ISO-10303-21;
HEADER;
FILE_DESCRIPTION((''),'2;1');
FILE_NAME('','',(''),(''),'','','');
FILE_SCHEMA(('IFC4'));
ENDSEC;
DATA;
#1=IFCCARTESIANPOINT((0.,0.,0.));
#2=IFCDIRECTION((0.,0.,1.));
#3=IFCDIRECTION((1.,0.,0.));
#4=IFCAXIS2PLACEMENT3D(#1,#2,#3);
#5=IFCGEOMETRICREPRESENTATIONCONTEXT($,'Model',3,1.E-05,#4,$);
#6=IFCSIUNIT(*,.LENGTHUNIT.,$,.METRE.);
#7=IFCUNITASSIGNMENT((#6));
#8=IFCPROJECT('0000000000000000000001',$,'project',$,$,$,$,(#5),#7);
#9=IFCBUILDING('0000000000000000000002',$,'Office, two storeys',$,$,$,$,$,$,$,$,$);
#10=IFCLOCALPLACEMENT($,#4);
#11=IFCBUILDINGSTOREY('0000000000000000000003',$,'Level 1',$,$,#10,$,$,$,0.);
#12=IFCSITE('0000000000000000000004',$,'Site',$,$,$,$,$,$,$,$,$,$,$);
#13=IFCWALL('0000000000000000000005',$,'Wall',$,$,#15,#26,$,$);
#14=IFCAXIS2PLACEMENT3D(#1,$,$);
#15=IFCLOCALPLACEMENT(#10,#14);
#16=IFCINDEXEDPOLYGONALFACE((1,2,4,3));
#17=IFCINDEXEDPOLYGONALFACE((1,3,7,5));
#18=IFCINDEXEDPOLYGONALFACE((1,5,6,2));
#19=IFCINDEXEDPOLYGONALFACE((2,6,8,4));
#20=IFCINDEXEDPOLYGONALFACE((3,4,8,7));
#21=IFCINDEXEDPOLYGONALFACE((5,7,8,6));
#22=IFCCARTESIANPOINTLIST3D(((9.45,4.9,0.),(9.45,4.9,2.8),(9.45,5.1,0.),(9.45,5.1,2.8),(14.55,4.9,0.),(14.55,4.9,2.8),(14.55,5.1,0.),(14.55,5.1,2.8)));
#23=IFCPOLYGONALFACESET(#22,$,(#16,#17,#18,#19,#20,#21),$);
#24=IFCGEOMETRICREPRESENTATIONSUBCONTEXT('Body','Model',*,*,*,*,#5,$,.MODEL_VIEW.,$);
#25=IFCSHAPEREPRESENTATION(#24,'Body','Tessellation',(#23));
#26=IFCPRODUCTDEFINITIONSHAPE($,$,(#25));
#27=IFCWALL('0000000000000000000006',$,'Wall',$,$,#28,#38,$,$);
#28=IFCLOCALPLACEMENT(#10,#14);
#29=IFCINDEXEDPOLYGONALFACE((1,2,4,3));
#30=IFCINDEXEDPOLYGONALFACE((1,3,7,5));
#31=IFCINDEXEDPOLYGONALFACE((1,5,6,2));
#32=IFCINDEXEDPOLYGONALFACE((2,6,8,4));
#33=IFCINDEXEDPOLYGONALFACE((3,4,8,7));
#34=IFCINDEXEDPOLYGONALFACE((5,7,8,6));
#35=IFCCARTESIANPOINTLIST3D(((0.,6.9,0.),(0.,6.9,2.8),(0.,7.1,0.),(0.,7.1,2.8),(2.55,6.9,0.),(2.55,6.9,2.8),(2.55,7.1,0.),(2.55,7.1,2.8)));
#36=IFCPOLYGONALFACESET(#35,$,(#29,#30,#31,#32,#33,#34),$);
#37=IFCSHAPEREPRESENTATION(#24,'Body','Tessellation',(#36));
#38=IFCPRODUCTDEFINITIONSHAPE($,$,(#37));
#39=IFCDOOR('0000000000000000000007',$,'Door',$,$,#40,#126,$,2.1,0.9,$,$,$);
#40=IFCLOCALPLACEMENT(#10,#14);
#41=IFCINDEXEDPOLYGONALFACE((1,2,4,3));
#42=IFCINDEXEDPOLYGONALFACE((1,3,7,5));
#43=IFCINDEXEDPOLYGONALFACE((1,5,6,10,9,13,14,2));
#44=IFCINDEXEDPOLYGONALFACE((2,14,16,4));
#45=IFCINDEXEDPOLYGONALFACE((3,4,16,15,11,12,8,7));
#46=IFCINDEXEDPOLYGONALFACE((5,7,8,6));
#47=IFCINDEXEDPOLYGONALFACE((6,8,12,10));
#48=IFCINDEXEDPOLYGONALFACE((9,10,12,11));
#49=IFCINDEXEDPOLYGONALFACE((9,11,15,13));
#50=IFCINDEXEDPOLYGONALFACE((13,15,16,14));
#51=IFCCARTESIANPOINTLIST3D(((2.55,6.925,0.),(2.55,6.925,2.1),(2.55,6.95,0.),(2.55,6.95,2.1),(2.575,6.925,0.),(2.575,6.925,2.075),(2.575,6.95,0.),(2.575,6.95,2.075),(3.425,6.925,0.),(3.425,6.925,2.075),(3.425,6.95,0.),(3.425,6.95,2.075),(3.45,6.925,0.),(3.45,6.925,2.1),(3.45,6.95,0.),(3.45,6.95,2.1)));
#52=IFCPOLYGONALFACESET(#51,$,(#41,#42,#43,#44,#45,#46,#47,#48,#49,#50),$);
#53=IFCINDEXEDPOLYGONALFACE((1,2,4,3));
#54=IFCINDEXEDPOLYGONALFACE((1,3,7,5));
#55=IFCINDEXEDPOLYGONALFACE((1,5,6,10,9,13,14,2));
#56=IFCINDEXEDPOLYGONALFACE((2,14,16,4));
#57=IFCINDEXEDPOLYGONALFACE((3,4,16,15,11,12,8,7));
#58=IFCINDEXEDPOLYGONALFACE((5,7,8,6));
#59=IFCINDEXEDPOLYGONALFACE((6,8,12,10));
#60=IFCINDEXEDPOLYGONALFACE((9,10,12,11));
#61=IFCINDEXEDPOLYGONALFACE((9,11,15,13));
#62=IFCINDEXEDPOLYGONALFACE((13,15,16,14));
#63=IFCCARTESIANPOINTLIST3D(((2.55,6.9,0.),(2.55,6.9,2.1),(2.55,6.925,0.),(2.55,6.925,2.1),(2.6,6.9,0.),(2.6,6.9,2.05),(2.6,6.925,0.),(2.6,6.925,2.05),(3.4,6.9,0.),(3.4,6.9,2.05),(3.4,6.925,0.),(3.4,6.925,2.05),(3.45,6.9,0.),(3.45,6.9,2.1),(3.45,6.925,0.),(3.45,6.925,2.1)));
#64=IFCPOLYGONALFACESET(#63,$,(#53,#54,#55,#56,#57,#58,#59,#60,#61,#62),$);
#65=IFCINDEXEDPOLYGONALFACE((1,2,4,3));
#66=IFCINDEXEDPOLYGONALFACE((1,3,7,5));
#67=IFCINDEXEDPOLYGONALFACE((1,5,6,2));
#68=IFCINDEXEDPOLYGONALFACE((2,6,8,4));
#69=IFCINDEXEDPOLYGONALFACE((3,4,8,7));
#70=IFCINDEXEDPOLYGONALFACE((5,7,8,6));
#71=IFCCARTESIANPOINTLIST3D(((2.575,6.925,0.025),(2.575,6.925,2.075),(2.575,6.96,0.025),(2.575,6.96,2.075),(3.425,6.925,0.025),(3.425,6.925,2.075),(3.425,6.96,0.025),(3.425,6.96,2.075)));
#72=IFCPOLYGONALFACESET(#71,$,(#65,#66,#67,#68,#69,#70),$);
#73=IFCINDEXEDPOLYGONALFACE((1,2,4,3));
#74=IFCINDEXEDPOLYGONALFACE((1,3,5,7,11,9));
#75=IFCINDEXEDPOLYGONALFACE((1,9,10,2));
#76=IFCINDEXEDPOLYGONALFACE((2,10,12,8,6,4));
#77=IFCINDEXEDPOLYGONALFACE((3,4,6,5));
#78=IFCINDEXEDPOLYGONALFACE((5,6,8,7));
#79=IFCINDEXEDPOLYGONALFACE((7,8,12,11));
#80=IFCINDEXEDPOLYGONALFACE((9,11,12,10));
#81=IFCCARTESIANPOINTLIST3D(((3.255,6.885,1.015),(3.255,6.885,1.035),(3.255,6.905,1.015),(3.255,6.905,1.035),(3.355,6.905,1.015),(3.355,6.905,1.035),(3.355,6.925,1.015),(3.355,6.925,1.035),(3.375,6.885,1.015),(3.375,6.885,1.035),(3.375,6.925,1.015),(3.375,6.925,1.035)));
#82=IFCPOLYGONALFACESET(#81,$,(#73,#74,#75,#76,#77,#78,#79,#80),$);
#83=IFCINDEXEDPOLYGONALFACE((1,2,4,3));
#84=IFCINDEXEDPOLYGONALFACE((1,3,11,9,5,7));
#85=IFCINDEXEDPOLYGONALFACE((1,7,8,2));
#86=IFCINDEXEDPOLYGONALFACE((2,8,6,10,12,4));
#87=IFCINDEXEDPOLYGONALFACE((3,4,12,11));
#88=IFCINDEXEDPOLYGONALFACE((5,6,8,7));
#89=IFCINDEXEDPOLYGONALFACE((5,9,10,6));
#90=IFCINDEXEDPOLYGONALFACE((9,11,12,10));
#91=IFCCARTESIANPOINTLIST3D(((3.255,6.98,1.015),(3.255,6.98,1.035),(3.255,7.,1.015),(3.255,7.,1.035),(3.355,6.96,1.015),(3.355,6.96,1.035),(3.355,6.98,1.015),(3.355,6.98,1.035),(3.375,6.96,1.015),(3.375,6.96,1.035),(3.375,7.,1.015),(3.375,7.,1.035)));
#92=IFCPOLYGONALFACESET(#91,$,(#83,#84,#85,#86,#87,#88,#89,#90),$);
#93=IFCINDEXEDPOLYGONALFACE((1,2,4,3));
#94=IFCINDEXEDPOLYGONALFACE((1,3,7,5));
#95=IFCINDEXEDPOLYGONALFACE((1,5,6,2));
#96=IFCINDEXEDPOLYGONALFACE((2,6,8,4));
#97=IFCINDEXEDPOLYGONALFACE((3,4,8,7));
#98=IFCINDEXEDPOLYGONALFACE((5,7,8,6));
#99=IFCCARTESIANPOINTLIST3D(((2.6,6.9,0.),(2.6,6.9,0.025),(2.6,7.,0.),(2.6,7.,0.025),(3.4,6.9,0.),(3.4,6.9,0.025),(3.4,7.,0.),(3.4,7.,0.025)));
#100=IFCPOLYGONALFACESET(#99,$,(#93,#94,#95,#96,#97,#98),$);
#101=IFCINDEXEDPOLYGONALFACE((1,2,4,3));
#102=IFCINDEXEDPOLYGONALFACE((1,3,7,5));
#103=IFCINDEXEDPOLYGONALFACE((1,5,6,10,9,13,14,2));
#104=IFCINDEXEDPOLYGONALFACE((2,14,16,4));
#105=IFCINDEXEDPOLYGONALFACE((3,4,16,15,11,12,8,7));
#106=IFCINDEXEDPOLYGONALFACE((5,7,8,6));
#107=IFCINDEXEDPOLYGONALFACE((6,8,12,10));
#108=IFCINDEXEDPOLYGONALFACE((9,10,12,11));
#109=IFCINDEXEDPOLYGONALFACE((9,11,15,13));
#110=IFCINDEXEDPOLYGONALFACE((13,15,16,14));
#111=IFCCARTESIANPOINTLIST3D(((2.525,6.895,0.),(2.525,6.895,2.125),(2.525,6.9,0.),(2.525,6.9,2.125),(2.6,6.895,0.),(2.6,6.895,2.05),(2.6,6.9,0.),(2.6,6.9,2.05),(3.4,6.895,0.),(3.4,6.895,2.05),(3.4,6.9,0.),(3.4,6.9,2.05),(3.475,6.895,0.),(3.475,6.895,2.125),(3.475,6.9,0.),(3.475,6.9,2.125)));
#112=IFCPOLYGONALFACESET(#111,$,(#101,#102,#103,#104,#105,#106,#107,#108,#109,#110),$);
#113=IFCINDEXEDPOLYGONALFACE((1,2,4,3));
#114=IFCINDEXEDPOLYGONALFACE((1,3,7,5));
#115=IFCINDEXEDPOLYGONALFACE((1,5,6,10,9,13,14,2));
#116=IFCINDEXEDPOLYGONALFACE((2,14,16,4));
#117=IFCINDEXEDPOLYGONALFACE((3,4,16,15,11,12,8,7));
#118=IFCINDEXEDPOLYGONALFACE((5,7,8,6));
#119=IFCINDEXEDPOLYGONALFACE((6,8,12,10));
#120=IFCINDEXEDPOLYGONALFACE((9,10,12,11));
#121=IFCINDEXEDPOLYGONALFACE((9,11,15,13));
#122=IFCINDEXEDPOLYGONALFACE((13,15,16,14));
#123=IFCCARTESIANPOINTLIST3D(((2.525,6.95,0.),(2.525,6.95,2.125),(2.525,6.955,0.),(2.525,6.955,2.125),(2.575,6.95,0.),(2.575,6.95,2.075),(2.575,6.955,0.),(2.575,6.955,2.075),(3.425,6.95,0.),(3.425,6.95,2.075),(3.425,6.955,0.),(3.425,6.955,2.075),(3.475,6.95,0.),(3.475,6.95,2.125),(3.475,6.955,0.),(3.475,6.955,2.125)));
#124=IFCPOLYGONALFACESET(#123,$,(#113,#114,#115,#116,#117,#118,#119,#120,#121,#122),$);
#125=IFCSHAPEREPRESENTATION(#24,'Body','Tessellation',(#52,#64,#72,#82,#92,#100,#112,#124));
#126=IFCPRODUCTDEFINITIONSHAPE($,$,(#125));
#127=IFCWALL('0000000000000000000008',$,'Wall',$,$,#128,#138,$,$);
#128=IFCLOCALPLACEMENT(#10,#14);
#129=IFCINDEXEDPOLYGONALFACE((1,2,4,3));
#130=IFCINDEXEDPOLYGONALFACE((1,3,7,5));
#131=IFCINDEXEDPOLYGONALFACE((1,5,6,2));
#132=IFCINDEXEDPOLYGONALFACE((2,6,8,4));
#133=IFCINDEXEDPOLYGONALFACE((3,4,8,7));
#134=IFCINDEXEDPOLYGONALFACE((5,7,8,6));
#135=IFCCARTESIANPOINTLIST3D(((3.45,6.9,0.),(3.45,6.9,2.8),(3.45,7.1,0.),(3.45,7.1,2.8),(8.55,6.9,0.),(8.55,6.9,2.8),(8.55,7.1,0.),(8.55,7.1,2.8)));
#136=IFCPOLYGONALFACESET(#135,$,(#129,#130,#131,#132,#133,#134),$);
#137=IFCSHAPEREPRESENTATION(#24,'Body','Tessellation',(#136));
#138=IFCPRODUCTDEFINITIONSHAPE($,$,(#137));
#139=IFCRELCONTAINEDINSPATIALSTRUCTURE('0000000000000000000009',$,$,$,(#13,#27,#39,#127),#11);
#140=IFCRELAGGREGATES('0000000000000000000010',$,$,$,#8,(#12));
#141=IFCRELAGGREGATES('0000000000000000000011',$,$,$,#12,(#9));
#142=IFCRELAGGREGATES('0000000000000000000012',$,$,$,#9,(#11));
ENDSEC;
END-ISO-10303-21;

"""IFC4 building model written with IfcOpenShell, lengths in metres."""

from ifc_helpers import new_model, si_unit, frame, origin_with_axes, place, context, subcontext, project, spatial, line, indexed_curve, outline, extrude, element, save


model = new_model("IFC4")

# Units and contexts
model_context = context("Model", 3, precision=1e-05, world=origin_with_axes())
body_context = subcontext(model_context, "Body", "Model", "MODEL_VIEW")
ifc_project = project(units=[si_unit("LENGTHUNIT", "METRE")], contexts=[model_context])

# Site, building, storey
site = spatial("IfcSite", under=ifc_project, Name="Site")
building = spatial("IfcBuilding", under=site, Name="Office, two storeys")
storey_placement = place(None, origin_with_axes())
storey = spatial("IfcBuildingStorey", under=building, at=storey_placement, Name="Level 1", Elevation=0.0)

# Walls
wall_1_placement = place(storey_placement, frame((9.45, 5.0, 0.0), z_axis=(0.0, 0.0, 1.0), x_axis=(1.0, 0.0, 0.0)))
element("IfcWall", 1, at=wall_1_placement, inside=storey, Name="Wall", context=body_context, shape_type="SweptSolid", body=[
    extrude(outline(indexed_curve([(0.0, 0.0), (0.0, 0.2), (5.1, 0.2), (5.1, 0.0), (0.0, 0.0)], self_intersect=False)), frame((0.0, -0.1, 0.0), z_axis=(0.0, 0.0, 1.0), x_axis=(1.0, 0.0, 0.0)), (0.0, 0.0, 1.0), 2.8),
])
wall_2_placement = place(storey_placement, frame((0.0, 7.0, 0.0), z_axis=(0.0, 0.0, 1.0), x_axis=(1.0, 0.0, 0.0)))
element("IfcWall", 2, at=wall_2_placement, inside=storey, Name="Wall", context=body_context, shape_type="SweptSolid", body=[
    extrude(outline(indexed_curve([(0.0, 0.0), (0.0, 0.2), (2.55, 0.2), (2.55, 0.0), (0.0, 0.0)], self_intersect=False)), frame((0.0, -0.1, 0.0), z_axis=(0.0, 0.0, 1.0), x_axis=(1.0, 0.0, 0.0)), (0.0, 0.0, 1.0), 2.8),
])

# Door
door_1_placement = place(storey_placement, frame((2.55, 6.9, 0.0), z_axis=(0.0, 0.0, 1.0), x_axis=(1.0, 0.0, 0.0)))
element("IfcDoor", 3, at=door_1_placement, inside=storey, Name="Door", OverallHeight=2.1, OverallWidth=0.9, context=body_context, shape_type="SweptSolid", body=[
    extrude(outline(indexed_curve([(0.0, 0.0), (0.0, 2.1), (0.9, 2.1), (0.9, 0.0), (0.875, 0.0), (0.875, 2.075), (0.025, 2.075), (0.025, 0.0)], segments=[line(1, 2, 3, 4, 5, 6, 7, 8, 1)])), frame((0.0, 0.025, 0.0), z_axis=(0.0, -1.0, 0.0), x_axis=(1.0, 0.0, 0.0)), (0.0, 0.0, -1.0), 0.025),
    extrude(outline(indexed_curve([(0.0, 0.0), (0.0, 2.1), (0.9, 2.1), (0.9, 0.0), (0.85, 0.0), (0.85, 2.05), (0.05, 2.05), (0.05, 0.0)], segments=[line(1, 2, 3, 4, 5, 6, 7, 8, 1)])), frame((0.0, 0.0, 0.0), z_axis=(0.0, -1.0, 0.0), x_axis=(1.0, 0.0, 0.0)), (0.0, 0.0, -1.0), 0.025),
    extrude(outline(indexed_curve([(0.0, 0.0), (0.85, 0.0), (0.85, 0.035), (0.0, 0.035)], segments=[line(1, 2, 3, 4, 1)])), frame((0.025, 0.025, 0.025), z_axis=(0.0, 0.0, 1.0), x_axis=(1.0, 0.0, 0.0)), (0.0, 0.0, 1.0), 2.05),
    extrude(outline(indexed_curve([(0.0, 0.0), (0.0, -0.04), (-0.12, -0.04), (-0.12, -0.02), (-0.02, -0.02), (-0.02, 0.0)], segments=[line(1, 2, 3, 4, 5, 6, 1)])), frame((0.825, 0.025, 1.015), z_axis=(0.0, 0.0, 1.0), x_axis=(1.0, 0.0, 0.0)), (0.0, 0.0, 1.0), 0.02),
    extrude(outline(indexed_curve([(0.0, 0.0), (0.0, 0.04), (-0.12, 0.04), (-0.12, 0.02), (-0.02, 0.02), (-0.02, 0.0)], segments=[line(1, 2, 3, 4, 5, 6, 1)])), frame((0.825, 0.06, 1.015), z_axis=(0.0, 0.0, 1.0), x_axis=(1.0, 0.0, 0.0)), (0.0, 0.0, 1.0), 0.02),
    extrude(outline(indexed_curve([(0.0, 0.0), (0.8, 0.0), (0.8, 0.1), (0.0, 0.1)], segments=[line(1, 2, 3, 4, 1)])), frame((0.05, 0.0, 0.0), z_axis=(0.0, 0.0, 1.0), x_axis=(1.0, 0.0, 0.0)), (0.0, 0.0, 1.0), 0.025),
    extrude(outline(indexed_curve([(0.0, 0.0), (0.0, 2.125), (0.95, 2.125), (0.95, 0.0), (0.875, 0.0), (0.875, 2.05), (0.075, 2.05), (0.075, 0.0)], segments=[line(1, 2, 3, 4, 5, 6, 7, 8, 1)])), frame((-0.025, -0.005, 0.0), z_axis=(0.0, -1.0, 0.0), x_axis=(1.0, 0.0, 0.0)), (0.0, 0.0, -1.0), 0.005),
    extrude(outline(indexed_curve([(0.0, 0.0), (0.0, 2.125), (0.95, 2.125), (0.95, 0.0), (0.9, 0.0), (0.9, 2.075), (0.05, 2.075), (0.05, 0.0)], segments=[line(1, 2, 3, 4, 5, 6, 7, 8, 1)])), frame((-0.025, 0.05, 0.0), z_axis=(0.0, -1.0, 0.0), x_axis=(1.0, 0.0, 0.0)), (0.0, 0.0, -1.0), 0.005),
])

# Wall
wall_3_placement = place(storey_placement, frame((3.45, 7.0, 0.0), z_axis=(0.0, 0.0, 1.0), x_axis=(1.0, 0.0, 0.0)))
element("IfcWall", 4, at=wall_3_placement, inside=storey, Name="Wall", context=body_context, shape_type="SweptSolid", body=[
    extrude(outline(indexed_curve([(0.0, 0.0), (0.0, 0.2), (5.1, 0.2), (5.1, 0.0), (0.0, 0.0)], self_intersect=False)), frame((0.0, -0.1, 0.0), z_axis=(0.0, 0.0, 1.0), x_axis=(1.0, 0.0, 0.0)), (0.0, 0.0, 1.0), 2.8),
])

save(model, "model.ifc")
